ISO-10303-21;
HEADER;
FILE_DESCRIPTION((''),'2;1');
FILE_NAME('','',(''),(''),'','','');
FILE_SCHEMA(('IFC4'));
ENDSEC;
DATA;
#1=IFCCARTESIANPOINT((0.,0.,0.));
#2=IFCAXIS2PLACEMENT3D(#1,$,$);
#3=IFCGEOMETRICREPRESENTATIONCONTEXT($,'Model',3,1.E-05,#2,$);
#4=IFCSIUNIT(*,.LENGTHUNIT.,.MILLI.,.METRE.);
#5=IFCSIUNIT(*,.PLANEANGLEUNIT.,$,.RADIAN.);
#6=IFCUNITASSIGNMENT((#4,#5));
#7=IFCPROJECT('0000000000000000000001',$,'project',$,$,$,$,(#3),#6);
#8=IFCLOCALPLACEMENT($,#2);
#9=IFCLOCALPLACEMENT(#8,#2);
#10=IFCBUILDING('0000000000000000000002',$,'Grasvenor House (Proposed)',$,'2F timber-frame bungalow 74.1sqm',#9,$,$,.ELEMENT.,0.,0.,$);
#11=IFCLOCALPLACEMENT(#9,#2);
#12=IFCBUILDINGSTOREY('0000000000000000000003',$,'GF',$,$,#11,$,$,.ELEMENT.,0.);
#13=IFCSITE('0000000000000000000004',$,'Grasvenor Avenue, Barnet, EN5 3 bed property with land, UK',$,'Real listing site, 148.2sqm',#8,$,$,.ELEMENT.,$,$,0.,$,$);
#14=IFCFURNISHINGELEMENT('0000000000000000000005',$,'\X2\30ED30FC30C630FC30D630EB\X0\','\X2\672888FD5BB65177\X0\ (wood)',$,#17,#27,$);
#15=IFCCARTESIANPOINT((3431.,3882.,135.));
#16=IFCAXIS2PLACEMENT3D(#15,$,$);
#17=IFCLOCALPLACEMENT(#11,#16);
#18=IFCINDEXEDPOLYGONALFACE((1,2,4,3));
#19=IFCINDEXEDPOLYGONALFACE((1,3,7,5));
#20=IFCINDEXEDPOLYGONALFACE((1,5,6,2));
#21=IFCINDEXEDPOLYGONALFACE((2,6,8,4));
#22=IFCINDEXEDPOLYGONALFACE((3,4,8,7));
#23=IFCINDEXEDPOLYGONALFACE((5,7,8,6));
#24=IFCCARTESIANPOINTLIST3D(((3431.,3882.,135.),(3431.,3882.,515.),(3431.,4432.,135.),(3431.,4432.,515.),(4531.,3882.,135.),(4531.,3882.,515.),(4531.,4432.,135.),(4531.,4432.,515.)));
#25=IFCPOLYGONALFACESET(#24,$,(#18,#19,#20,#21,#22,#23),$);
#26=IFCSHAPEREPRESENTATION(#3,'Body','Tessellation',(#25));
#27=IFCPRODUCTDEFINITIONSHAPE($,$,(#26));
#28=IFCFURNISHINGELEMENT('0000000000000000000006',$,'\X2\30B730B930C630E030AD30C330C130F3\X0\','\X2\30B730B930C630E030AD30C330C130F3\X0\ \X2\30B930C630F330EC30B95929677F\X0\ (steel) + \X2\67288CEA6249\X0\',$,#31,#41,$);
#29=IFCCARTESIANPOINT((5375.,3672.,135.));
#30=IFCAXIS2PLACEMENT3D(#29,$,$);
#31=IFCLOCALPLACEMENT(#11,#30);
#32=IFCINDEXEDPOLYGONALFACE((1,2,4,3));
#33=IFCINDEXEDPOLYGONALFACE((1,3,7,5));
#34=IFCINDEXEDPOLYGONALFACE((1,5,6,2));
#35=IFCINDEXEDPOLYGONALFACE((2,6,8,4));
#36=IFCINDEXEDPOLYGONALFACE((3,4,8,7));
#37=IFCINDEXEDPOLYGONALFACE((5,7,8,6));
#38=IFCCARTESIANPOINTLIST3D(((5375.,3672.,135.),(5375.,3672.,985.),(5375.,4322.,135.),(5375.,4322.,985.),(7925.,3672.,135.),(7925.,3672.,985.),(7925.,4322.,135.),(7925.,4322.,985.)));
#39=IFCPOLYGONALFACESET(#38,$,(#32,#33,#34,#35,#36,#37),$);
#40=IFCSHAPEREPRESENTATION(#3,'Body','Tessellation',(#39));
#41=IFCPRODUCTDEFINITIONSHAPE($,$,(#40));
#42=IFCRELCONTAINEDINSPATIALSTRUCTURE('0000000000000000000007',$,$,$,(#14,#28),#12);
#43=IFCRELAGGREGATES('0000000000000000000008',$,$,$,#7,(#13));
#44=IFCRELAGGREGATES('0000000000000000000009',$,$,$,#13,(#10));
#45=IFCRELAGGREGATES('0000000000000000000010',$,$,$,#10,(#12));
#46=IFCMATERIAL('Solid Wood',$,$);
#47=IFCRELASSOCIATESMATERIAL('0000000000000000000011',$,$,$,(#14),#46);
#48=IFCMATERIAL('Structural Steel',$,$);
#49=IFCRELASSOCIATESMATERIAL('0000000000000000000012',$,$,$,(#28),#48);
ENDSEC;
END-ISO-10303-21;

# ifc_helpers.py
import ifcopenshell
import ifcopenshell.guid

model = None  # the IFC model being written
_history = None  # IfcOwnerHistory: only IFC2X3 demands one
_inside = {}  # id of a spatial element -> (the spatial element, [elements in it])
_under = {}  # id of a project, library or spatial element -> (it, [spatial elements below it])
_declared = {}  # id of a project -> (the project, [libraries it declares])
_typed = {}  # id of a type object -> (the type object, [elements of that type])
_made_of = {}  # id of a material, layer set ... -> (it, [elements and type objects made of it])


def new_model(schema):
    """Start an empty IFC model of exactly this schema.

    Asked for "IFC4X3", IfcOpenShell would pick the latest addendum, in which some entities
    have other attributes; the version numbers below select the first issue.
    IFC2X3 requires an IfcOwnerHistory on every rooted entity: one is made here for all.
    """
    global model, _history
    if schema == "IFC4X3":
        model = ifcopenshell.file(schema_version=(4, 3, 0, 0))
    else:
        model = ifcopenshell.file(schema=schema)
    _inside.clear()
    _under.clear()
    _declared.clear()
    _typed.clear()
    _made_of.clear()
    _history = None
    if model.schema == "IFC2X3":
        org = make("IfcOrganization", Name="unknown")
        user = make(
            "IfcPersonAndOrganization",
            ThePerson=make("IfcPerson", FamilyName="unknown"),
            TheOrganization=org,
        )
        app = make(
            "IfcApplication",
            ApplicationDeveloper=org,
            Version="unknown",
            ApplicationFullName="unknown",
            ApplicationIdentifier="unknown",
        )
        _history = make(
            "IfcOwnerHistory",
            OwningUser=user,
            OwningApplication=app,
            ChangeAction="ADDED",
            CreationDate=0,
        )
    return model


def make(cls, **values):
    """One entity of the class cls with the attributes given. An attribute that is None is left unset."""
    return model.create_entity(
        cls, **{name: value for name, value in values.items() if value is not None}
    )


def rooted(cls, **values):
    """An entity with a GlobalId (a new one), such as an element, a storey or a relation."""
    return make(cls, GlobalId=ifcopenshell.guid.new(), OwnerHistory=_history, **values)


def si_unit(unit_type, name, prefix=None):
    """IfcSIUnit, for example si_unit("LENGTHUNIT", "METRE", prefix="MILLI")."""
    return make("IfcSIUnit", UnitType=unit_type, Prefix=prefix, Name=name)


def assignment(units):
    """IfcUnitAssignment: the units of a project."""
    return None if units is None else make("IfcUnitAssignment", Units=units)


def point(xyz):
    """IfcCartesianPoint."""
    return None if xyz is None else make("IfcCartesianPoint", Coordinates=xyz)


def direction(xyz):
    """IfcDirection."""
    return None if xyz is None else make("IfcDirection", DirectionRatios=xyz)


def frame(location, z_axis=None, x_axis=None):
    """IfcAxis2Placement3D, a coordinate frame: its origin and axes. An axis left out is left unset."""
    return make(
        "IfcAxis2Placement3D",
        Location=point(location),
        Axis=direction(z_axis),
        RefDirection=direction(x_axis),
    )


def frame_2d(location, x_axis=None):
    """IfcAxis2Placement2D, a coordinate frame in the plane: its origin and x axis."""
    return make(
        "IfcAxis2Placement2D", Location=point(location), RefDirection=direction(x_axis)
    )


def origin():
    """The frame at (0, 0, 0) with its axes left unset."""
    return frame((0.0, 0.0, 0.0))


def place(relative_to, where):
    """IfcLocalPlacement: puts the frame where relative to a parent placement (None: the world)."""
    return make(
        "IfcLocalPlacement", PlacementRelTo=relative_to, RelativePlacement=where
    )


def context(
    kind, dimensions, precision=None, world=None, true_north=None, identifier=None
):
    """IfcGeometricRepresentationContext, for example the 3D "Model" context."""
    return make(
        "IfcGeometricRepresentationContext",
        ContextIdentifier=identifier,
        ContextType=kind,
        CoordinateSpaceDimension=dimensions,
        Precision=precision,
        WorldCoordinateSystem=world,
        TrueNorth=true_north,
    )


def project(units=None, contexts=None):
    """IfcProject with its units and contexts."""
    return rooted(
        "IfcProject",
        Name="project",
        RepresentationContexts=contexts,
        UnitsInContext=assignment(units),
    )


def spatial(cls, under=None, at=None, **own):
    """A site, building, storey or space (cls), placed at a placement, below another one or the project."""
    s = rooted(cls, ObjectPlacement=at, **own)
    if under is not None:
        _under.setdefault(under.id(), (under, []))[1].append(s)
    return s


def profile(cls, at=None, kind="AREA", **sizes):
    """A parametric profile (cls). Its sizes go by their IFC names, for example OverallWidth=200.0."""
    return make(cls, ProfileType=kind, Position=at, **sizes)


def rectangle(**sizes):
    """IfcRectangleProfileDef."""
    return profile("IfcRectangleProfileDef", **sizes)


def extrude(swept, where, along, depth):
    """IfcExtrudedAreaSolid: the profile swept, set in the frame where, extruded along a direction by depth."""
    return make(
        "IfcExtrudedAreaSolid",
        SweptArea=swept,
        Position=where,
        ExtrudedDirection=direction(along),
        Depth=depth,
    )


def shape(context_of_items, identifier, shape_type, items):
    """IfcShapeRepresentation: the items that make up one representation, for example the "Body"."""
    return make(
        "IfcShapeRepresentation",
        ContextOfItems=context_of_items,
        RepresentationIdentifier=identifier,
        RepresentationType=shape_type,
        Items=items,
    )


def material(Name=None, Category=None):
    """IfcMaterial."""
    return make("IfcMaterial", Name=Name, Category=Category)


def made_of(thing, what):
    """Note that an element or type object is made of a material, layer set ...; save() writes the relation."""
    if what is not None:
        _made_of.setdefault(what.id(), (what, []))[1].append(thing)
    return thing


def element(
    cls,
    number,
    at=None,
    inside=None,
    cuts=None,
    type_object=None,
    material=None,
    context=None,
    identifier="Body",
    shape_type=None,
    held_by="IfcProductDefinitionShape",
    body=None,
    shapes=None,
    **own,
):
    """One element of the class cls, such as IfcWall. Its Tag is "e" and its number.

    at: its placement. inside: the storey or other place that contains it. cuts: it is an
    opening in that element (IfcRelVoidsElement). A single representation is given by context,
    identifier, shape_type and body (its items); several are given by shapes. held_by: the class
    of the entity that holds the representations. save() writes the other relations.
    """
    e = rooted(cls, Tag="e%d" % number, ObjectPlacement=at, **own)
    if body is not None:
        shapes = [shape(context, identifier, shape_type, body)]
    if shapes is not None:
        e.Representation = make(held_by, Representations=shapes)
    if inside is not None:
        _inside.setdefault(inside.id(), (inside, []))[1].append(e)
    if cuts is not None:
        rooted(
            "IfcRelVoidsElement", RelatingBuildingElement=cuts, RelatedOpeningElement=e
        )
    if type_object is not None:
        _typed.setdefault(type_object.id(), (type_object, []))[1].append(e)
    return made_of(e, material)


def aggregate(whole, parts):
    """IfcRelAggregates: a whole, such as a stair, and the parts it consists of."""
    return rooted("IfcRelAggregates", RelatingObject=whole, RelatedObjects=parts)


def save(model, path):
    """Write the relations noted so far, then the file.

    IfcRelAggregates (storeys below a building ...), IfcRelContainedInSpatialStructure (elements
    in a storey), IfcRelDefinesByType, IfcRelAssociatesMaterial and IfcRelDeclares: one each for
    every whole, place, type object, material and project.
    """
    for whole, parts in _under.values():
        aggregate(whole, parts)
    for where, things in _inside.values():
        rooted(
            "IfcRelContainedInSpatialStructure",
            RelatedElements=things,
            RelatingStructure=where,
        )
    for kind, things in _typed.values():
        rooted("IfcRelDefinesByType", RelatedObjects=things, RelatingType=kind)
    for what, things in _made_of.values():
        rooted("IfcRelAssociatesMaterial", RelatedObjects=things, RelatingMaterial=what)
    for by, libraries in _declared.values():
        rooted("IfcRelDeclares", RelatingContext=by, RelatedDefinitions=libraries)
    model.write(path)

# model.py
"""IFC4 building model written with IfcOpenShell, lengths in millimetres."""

from ifc_helpers import new_model, si_unit, frame, frame_2d, origin, place, context, project, spatial, rectangle, extrude, material, element, save


model = new_model("IFC4")

# Units and contexts
model_context = context("Model", 3, precision=1e-05, world=origin())
ifc_project = project(units=[si_unit("LENGTHUNIT", "METRE", prefix="MILLI"), si_unit("PLANEANGLEUNIT", "RADIAN")], contexts=[model_context])

# Site, building, storey
site_placement = place(None, origin())
site = spatial("IfcSite", under=ifc_project, at=site_placement, Name="Grasvenor Avenue, Barnet, EN5 3 bed property with land, UK", ObjectType="Real listing site, 148.2sqm", CompositionType="ELEMENT", RefElevation=0.0)
building_placement = place(site_placement, origin())
building = spatial("IfcBuilding", under=site, at=building_placement, Name="Grasvenor House (Proposed)", ObjectType="2F timber-frame bungalow 74.1sqm", CompositionType="ELEMENT", ElevationOfRefHeight=0.0, ElevationOfTerrain=0.0)
storey_placement = place(building_placement, origin())
storey = spatial("IfcBuildingStorey", under=building, at=storey_placement, Name="GF", CompositionType="ELEMENT", Elevation=0.0)

# Shared definitions
ifc_material_1 = material(Name="Solid Wood")

# Furnishing elements
furnishing_1_placement = place(storey_placement, frame((3431.0, 3882.0, 135.0)))
element("IfcFurnishingElement", 1, at=furnishing_1_placement, inside=storey, material=ifc_material_1, Name="ローテーブル", Description="木製家具 (wood)", context=model_context, shape_type="SweptSolid", body=[
    extrude(rectangle(XDim=1100.0, YDim=550.0, at=frame_2d((550.0, 275.0))), frame((3431.0, 3882.0, 135.0)), (0.0, 0.0, 1.0), 380.0),
])
ifc_material_2 = material(Name="Structural Steel")
furnishing_2_placement = place(storey_placement, frame((5375.0, 3672.0, 135.0)))
element("IfcFurnishingElement", 2, at=furnishing_2_placement, inside=storey, material=ifc_material_2, Name="システムキッチン", Description="システムキッチン ステンレス天板 (steel) + 木質扉", context=model_context, shape_type="SweptSolid", body=[
    extrude(rectangle(XDim=2550.0, YDim=650.0, at=frame_2d((1275.0, 325.0))), frame((5375.0, 3672.0, 135.0)), (0.0, 0.0, 1.0), 850.0),
])

save(model, "model.ifc")
